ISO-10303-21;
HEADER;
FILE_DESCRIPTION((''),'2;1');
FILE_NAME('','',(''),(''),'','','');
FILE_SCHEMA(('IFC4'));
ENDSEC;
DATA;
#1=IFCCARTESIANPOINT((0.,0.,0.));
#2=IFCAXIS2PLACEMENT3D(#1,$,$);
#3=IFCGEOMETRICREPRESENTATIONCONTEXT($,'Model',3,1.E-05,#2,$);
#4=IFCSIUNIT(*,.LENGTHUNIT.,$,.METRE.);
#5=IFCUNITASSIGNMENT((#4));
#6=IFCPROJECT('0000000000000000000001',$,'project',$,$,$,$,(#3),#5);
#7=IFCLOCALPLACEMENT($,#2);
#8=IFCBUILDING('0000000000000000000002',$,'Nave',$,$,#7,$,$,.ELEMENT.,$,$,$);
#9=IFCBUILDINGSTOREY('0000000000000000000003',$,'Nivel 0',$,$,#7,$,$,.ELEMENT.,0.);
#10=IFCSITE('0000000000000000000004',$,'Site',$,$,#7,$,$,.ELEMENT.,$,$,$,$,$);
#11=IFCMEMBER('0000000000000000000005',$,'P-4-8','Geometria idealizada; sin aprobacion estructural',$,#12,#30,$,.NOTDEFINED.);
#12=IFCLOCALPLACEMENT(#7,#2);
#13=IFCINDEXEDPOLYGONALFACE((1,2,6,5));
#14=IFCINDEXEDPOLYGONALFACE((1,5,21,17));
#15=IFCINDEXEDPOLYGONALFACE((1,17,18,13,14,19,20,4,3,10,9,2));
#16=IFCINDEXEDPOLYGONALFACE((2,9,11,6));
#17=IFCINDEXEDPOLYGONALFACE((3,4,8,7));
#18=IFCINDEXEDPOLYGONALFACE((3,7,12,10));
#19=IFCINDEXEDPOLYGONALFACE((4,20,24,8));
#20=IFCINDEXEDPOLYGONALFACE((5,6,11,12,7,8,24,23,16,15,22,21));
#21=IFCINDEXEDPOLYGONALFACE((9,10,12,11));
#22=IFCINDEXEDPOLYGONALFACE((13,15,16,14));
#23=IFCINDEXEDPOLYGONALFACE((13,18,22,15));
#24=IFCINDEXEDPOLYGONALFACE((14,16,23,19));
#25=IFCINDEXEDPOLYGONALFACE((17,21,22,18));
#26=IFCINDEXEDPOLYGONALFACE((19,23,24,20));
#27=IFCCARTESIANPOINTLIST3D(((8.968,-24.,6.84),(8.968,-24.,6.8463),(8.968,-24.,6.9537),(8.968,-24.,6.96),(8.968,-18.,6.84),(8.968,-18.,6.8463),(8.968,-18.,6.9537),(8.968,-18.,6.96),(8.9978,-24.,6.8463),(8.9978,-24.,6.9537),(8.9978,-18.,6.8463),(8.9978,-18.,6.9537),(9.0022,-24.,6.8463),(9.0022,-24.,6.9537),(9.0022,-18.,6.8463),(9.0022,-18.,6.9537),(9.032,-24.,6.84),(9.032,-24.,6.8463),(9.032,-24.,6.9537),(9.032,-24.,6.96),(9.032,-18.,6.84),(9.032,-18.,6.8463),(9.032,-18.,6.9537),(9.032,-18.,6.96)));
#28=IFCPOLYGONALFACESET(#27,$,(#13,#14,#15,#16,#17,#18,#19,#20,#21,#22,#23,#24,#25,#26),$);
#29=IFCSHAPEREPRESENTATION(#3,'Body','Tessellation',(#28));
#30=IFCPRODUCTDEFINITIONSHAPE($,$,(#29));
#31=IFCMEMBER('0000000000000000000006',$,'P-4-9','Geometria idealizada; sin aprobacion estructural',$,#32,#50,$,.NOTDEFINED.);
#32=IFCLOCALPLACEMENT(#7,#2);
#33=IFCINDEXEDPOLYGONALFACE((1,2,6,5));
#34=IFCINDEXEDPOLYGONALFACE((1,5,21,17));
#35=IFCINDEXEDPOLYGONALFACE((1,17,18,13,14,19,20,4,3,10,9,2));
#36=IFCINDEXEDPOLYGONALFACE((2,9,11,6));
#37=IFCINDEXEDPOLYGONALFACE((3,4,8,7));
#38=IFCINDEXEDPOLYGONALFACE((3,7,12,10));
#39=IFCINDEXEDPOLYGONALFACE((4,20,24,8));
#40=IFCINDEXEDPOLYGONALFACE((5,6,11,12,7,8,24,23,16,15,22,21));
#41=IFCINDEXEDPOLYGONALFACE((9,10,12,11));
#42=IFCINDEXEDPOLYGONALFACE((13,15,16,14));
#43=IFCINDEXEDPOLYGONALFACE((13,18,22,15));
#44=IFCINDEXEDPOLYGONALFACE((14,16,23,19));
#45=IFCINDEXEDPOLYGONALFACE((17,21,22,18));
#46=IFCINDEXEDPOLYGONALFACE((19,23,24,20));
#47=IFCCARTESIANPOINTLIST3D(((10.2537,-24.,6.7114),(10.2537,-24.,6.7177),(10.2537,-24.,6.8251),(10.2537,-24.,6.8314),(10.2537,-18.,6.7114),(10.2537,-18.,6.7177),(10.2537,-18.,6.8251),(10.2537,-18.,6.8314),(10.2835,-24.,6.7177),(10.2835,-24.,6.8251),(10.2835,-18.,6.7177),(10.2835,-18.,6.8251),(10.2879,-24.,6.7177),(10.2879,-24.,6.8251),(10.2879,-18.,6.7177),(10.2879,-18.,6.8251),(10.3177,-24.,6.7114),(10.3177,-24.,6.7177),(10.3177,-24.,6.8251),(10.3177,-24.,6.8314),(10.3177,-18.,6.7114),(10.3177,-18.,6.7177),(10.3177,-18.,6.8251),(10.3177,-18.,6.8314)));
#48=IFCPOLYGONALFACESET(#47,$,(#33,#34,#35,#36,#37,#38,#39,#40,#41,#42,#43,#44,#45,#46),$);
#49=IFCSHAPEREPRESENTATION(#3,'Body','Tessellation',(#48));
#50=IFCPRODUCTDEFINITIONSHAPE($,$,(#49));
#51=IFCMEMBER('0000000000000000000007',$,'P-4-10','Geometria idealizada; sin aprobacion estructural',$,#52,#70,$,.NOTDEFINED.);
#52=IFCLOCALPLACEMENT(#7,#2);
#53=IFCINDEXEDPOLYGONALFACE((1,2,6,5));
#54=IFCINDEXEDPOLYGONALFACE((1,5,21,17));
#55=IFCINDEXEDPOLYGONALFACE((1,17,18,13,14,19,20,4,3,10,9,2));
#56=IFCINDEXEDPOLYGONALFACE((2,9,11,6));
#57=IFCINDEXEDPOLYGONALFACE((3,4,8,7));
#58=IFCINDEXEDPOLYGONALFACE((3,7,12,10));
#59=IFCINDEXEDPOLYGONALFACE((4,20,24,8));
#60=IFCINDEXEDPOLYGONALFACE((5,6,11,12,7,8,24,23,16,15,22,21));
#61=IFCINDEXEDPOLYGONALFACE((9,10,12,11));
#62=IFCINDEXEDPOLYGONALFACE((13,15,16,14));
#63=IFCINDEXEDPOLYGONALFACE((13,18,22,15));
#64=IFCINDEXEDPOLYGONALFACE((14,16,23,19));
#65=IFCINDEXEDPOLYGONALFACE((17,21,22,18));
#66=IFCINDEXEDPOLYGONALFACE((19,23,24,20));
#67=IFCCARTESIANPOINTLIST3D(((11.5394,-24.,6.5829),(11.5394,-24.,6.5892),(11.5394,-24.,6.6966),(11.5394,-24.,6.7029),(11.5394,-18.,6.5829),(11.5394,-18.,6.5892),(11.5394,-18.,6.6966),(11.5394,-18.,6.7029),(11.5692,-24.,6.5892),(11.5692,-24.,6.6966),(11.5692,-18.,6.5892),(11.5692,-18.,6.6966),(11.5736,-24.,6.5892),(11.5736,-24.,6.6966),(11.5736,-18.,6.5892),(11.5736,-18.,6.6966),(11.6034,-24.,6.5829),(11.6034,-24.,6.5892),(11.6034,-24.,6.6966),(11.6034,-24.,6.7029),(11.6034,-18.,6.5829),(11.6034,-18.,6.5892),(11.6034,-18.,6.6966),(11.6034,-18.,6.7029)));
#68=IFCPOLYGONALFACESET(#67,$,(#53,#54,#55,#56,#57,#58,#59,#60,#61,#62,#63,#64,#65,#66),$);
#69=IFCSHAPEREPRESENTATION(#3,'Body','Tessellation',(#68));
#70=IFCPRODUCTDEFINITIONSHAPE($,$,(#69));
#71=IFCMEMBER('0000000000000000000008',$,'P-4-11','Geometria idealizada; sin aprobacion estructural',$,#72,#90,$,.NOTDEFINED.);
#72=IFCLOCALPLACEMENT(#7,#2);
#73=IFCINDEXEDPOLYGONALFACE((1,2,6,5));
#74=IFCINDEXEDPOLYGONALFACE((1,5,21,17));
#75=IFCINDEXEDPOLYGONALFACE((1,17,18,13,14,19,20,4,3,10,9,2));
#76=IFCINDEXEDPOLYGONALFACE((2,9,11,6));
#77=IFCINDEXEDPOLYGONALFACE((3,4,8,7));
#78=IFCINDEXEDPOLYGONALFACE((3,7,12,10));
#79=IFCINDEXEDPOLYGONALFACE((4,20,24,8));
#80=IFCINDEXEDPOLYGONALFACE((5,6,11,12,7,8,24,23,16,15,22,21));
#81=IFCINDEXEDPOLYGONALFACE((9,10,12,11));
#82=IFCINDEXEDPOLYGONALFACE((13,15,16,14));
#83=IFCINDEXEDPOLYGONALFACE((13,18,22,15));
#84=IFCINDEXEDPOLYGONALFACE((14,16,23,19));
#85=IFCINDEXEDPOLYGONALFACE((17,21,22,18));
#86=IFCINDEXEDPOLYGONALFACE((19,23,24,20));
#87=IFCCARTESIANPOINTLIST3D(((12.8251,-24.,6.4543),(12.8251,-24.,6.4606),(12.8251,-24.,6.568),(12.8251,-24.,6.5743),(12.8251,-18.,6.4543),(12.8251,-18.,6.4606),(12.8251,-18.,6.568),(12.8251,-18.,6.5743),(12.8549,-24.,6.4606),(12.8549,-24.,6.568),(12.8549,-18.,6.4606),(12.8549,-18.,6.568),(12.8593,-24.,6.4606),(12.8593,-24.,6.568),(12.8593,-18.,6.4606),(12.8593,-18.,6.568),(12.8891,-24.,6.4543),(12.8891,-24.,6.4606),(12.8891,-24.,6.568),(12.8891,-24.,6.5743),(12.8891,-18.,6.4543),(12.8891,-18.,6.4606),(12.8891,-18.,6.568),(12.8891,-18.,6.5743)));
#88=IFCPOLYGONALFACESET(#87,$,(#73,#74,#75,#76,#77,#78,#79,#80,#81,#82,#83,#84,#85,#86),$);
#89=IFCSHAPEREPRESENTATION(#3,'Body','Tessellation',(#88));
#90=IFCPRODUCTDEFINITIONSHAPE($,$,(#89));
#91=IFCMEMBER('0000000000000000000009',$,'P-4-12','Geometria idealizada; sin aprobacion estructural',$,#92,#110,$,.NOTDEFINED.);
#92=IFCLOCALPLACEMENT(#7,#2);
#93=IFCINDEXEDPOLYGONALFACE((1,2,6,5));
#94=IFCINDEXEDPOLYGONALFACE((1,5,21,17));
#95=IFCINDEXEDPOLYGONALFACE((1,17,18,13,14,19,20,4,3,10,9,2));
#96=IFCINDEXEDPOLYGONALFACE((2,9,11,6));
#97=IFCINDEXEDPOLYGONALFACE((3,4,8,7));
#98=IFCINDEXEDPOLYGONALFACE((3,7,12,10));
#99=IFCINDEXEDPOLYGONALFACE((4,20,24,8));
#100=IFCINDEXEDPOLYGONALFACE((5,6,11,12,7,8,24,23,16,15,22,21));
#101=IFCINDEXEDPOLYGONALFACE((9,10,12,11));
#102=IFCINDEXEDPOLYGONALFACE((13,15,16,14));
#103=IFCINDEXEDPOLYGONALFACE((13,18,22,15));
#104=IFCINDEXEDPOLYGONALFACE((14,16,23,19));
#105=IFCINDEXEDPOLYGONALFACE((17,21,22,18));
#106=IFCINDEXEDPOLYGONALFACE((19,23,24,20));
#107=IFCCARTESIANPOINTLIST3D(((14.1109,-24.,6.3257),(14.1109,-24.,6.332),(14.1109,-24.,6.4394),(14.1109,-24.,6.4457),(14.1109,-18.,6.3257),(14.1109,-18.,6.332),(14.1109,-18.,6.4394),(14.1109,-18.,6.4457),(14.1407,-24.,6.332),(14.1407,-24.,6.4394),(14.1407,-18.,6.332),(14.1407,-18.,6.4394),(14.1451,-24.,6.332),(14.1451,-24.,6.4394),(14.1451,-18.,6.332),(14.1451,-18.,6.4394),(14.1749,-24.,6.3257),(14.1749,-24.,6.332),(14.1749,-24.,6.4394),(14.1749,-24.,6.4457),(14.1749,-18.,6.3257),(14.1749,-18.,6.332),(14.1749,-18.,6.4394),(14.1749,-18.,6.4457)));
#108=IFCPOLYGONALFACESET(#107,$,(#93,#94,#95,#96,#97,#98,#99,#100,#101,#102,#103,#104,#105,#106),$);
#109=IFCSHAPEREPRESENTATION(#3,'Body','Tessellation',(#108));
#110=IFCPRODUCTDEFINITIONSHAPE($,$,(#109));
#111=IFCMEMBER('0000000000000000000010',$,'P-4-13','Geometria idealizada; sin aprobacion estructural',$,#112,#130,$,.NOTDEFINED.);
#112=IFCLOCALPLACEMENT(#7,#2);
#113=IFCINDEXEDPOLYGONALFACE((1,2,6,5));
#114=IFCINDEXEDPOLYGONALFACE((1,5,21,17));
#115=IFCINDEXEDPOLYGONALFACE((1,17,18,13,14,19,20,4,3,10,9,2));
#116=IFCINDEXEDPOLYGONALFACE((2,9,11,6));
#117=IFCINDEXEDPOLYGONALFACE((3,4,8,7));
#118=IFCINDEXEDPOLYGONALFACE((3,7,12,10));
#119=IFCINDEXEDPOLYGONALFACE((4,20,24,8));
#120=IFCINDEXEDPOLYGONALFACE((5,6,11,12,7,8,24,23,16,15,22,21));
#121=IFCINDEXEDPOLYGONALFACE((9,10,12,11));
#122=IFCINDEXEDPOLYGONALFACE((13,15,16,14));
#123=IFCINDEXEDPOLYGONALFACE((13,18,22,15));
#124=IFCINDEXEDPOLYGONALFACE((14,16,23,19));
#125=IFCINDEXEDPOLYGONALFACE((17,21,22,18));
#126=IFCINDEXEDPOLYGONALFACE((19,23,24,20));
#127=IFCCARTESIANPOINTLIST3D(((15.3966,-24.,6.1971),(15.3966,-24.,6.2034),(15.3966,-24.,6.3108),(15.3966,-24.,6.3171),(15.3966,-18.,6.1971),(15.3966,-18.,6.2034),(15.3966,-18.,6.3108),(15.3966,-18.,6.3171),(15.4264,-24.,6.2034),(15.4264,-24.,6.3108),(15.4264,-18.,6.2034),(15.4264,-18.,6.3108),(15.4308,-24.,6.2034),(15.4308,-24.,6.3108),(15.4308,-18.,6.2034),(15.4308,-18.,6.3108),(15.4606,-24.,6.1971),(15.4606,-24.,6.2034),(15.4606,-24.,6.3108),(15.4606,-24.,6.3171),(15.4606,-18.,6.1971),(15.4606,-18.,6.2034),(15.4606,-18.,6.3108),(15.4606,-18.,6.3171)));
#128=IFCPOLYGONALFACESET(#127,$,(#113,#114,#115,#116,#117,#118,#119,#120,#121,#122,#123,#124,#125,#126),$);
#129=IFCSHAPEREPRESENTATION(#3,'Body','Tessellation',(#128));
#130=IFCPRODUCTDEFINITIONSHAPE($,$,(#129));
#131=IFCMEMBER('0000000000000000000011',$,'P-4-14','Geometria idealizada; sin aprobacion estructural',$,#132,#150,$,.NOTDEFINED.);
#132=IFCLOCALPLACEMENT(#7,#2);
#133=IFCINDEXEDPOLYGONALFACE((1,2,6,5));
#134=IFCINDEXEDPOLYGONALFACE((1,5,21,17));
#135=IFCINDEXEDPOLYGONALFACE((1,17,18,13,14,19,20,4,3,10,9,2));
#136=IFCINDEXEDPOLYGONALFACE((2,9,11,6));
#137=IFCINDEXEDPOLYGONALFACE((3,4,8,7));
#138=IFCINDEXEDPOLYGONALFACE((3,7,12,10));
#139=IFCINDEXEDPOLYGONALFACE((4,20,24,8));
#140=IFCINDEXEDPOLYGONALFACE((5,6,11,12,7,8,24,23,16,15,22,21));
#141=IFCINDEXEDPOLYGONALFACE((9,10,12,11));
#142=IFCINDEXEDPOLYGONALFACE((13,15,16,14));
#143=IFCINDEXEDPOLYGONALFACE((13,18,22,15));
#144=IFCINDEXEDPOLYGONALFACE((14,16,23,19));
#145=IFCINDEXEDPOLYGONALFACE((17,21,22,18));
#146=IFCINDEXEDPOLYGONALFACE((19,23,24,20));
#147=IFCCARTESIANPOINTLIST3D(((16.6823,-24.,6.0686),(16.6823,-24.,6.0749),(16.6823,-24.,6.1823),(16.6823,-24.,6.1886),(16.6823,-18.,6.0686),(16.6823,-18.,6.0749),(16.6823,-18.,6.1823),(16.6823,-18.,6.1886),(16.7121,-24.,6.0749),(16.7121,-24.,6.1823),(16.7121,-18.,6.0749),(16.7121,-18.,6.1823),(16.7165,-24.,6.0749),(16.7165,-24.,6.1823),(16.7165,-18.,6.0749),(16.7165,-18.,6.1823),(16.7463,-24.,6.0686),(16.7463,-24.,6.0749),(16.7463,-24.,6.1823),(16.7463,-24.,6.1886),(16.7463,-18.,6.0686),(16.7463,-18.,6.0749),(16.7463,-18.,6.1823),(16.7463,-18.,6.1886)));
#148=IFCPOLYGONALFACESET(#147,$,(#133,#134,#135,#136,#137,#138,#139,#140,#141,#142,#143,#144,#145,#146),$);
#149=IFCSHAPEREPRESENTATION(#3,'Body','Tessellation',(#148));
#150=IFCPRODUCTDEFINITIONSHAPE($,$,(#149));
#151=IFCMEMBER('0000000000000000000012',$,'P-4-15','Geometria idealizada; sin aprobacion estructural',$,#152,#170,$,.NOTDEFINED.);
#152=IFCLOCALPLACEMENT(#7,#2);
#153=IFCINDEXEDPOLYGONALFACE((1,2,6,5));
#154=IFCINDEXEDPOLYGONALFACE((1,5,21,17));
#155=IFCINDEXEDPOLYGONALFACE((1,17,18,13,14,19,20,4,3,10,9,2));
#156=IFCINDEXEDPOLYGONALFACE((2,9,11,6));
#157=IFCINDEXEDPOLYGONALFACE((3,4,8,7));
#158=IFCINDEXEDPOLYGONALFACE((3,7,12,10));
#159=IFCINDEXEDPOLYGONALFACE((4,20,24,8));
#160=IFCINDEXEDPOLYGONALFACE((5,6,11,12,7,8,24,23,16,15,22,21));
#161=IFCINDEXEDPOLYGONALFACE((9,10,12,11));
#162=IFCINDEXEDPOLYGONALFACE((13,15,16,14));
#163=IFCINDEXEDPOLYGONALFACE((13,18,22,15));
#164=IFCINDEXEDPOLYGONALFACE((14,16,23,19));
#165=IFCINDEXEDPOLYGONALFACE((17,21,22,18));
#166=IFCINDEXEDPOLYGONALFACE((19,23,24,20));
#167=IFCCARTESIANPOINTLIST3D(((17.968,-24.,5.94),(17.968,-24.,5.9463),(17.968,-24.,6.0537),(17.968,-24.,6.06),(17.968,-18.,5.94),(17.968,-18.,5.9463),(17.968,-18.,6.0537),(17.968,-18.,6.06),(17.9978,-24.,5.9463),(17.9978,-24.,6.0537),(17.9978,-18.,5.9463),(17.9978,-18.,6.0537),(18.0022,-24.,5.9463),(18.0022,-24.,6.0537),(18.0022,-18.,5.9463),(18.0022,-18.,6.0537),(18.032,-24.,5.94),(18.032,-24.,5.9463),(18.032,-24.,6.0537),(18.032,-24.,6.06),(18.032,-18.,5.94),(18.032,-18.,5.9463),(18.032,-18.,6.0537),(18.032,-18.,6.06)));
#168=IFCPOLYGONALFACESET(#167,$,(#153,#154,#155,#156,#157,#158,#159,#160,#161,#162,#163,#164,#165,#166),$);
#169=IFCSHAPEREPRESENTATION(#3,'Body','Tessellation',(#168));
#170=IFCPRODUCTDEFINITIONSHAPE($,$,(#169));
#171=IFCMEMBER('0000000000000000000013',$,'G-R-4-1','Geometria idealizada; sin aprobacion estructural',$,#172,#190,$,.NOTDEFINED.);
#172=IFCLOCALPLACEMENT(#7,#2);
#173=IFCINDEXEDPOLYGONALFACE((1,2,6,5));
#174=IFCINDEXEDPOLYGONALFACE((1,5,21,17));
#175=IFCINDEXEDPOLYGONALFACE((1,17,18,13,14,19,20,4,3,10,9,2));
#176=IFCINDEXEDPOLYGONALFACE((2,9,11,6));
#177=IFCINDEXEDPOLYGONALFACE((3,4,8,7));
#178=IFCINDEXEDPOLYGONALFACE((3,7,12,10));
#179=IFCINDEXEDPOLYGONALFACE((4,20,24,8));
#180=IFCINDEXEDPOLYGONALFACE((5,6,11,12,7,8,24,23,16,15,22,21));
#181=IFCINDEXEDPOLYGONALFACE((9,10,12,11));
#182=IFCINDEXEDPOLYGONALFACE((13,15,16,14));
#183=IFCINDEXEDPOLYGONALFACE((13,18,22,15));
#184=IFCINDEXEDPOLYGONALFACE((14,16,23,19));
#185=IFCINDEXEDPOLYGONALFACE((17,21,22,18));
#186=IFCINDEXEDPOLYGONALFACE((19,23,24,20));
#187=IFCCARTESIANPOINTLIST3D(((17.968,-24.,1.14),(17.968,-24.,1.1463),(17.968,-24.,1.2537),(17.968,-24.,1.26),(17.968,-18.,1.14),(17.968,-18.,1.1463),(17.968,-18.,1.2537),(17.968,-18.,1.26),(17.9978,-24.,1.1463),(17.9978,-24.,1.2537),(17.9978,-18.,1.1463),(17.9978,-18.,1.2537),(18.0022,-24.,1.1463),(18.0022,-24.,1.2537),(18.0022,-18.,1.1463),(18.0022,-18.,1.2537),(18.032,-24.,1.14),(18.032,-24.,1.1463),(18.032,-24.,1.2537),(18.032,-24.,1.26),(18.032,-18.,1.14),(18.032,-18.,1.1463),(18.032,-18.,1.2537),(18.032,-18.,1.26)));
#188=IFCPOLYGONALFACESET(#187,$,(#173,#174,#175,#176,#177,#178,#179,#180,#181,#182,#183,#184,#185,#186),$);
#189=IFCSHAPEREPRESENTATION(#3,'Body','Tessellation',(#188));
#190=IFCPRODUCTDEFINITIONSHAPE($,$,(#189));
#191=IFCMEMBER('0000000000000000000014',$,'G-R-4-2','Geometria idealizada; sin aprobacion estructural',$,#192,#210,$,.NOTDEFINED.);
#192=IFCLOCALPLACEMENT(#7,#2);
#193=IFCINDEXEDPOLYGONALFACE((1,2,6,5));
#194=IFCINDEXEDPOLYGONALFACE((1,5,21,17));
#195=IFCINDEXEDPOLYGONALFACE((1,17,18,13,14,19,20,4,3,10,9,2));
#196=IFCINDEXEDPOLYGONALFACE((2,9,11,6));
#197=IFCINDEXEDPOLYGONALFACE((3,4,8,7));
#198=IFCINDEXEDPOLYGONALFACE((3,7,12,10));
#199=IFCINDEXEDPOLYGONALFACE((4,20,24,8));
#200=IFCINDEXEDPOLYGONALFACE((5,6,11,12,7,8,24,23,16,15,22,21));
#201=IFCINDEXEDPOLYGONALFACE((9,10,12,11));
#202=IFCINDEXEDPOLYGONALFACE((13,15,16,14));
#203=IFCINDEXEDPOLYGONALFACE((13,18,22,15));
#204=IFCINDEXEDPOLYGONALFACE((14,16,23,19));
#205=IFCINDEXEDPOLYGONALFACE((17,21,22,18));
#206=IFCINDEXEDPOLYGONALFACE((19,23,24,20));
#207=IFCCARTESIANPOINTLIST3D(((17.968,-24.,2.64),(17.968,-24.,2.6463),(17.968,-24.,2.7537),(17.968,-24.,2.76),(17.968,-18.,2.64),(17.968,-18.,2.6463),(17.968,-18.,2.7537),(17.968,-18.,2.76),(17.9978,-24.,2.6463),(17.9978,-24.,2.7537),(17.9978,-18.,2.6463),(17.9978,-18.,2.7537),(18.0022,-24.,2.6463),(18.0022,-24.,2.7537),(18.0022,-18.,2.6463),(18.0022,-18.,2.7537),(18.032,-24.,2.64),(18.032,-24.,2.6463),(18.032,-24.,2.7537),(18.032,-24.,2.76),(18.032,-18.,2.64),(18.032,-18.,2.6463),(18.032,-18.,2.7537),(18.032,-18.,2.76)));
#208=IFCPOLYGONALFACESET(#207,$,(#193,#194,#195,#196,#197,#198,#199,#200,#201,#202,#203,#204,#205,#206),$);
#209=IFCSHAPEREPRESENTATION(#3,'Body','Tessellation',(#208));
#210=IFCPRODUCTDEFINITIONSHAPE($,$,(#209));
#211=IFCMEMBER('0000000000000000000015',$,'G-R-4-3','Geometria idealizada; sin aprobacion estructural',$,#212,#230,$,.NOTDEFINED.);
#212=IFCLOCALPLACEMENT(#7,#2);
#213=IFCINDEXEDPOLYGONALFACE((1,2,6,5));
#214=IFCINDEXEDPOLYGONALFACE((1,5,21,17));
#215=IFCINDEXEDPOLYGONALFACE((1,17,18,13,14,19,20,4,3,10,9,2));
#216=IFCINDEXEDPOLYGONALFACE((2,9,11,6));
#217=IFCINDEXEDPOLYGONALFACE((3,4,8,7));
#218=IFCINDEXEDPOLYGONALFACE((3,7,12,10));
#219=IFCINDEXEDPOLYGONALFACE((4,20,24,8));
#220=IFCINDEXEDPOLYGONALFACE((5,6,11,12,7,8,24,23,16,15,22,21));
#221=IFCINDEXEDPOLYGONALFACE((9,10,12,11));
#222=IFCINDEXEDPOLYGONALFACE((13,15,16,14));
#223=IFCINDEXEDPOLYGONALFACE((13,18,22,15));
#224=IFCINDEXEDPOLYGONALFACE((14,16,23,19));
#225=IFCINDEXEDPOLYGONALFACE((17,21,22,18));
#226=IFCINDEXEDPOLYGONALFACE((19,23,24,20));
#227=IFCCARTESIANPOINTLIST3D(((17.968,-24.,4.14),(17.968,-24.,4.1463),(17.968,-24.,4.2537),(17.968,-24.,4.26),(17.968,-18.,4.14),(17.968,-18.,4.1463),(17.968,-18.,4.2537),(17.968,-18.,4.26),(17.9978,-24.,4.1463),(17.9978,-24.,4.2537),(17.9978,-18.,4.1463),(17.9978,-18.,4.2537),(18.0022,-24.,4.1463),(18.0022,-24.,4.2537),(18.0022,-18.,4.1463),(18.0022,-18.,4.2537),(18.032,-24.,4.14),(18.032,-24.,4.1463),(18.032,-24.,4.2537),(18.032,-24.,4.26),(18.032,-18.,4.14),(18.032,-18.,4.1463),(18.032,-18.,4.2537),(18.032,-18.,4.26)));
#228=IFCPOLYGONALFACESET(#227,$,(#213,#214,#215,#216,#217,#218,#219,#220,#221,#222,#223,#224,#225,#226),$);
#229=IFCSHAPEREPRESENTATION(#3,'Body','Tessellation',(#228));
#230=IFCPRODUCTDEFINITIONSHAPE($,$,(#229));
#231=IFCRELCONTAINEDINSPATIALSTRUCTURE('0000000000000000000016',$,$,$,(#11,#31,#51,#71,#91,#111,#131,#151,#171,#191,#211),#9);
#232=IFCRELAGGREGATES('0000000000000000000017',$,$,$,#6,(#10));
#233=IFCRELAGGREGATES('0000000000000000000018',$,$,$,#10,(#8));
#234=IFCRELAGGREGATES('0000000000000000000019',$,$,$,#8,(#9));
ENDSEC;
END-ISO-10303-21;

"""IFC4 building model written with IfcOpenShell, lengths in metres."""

from ifc_helpers import new_model, si_unit, frame, origin, place, context, project, spatial, polyline, outline, extrude, element, save


model = new_model("IFC4")

# Units and contexts
model_context = context("Model", 3, precision=1e-05, world=origin())
ifc_project = project(units=[si_unit("LENGTHUNIT", "METRE")], contexts=[model_context])

# Site, building, storey
placement = place(None, origin())
site = spatial("IfcSite", under=ifc_project, at=placement, Name="Site", CompositionType="ELEMENT")
building = spatial("IfcBuilding", under=site, at=placement, Name="Nave", CompositionType="ELEMENT")
storey = spatial("IfcBuildingStorey", under=building, at=placement, Name="Nivel 0", CompositionType="ELEMENT", Elevation=0.0)

# Members
for number, where, z_axis, x_axis, name in (
    (1, (9.0, -18.0, 6.9), (0.0, -1.0, 0.0), (1.0, 0.0, 0.0), "P-4-8"),
    (2, (10.2857, -18.0, 6.7714), (0.0, -1.0, 0.0), (1.0, 0.0, 0.0), "P-4-9"),
    (3, (11.5714, -18.0, 6.6429), (0.0, -1.0, 0.0), (1.0, 0.0, 0.0), "P-4-10"),
    (4, (12.8571, -18.0, 6.5143), (0.0, -1.0, 0.0), (1.0, 0.0, 0.0), "P-4-11"),
    (5, (14.1429, -18.0, 6.3857), (0.0, -1.0, 0.0), (1.0, 0.0, 0.0), "P-4-12"),
    (6, (15.4286, -18.0, 6.2571), (0.0, -1.0, 0.0), (1.0, 0.0, 0.0), "P-4-13"),
    (7, (16.7143, -18.0, 6.1286), (0.0, -1.0, 0.0), (1.0, 0.0, 0.0), "P-4-14"),
    (8, (18.0, -18.0, 6.0), (0.0, -1.0, 0.0), (1.0, 0.0, 0.0), "P-4-15"),
    (9, (18.0, -18.0, 1.2), (0.0, -1.0, 0.0), (1.0, 0.0, 0.0), "G-R-4-1"),
    (10, (18.0, -18.0, 2.7), (0.0, -1.0, 0.0), (1.0, 0.0, 0.0), "G-R-4-2"),
    (11, (18.0, -18.0, 4.2), (0.0, -1.0, 0.0), (1.0, 0.0, 0.0), "G-R-4-3"),
):
    element("IfcMember", number, at=place(placement, frame(where, z_axis=z_axis, x_axis=x_axis)), inside=storey, Name=name, Description="Geometria idealizada; sin aprobacion estructural", PredefinedType="NOTDEFINED", context=model_context, shape_type="SweptSolid", body=[
        extrude(outline(polyline([(-0.032, -0.06), (0.032, -0.06), (0.032, -0.0537), (0.0022, -0.0537), (0.0022, 0.0537), (0.032, 0.0537), (0.032, 0.06), (-0.032, 0.06), (-0.032, 0.0537), (-0.0022, 0.0537), (-0.0022, -0.0537), (-0.032, -0.0537), (-0.032, -0.06)])), origin(), (0.0, 0.0, 1.0), 6.0),
    ])

save(model, "model.ifc")
